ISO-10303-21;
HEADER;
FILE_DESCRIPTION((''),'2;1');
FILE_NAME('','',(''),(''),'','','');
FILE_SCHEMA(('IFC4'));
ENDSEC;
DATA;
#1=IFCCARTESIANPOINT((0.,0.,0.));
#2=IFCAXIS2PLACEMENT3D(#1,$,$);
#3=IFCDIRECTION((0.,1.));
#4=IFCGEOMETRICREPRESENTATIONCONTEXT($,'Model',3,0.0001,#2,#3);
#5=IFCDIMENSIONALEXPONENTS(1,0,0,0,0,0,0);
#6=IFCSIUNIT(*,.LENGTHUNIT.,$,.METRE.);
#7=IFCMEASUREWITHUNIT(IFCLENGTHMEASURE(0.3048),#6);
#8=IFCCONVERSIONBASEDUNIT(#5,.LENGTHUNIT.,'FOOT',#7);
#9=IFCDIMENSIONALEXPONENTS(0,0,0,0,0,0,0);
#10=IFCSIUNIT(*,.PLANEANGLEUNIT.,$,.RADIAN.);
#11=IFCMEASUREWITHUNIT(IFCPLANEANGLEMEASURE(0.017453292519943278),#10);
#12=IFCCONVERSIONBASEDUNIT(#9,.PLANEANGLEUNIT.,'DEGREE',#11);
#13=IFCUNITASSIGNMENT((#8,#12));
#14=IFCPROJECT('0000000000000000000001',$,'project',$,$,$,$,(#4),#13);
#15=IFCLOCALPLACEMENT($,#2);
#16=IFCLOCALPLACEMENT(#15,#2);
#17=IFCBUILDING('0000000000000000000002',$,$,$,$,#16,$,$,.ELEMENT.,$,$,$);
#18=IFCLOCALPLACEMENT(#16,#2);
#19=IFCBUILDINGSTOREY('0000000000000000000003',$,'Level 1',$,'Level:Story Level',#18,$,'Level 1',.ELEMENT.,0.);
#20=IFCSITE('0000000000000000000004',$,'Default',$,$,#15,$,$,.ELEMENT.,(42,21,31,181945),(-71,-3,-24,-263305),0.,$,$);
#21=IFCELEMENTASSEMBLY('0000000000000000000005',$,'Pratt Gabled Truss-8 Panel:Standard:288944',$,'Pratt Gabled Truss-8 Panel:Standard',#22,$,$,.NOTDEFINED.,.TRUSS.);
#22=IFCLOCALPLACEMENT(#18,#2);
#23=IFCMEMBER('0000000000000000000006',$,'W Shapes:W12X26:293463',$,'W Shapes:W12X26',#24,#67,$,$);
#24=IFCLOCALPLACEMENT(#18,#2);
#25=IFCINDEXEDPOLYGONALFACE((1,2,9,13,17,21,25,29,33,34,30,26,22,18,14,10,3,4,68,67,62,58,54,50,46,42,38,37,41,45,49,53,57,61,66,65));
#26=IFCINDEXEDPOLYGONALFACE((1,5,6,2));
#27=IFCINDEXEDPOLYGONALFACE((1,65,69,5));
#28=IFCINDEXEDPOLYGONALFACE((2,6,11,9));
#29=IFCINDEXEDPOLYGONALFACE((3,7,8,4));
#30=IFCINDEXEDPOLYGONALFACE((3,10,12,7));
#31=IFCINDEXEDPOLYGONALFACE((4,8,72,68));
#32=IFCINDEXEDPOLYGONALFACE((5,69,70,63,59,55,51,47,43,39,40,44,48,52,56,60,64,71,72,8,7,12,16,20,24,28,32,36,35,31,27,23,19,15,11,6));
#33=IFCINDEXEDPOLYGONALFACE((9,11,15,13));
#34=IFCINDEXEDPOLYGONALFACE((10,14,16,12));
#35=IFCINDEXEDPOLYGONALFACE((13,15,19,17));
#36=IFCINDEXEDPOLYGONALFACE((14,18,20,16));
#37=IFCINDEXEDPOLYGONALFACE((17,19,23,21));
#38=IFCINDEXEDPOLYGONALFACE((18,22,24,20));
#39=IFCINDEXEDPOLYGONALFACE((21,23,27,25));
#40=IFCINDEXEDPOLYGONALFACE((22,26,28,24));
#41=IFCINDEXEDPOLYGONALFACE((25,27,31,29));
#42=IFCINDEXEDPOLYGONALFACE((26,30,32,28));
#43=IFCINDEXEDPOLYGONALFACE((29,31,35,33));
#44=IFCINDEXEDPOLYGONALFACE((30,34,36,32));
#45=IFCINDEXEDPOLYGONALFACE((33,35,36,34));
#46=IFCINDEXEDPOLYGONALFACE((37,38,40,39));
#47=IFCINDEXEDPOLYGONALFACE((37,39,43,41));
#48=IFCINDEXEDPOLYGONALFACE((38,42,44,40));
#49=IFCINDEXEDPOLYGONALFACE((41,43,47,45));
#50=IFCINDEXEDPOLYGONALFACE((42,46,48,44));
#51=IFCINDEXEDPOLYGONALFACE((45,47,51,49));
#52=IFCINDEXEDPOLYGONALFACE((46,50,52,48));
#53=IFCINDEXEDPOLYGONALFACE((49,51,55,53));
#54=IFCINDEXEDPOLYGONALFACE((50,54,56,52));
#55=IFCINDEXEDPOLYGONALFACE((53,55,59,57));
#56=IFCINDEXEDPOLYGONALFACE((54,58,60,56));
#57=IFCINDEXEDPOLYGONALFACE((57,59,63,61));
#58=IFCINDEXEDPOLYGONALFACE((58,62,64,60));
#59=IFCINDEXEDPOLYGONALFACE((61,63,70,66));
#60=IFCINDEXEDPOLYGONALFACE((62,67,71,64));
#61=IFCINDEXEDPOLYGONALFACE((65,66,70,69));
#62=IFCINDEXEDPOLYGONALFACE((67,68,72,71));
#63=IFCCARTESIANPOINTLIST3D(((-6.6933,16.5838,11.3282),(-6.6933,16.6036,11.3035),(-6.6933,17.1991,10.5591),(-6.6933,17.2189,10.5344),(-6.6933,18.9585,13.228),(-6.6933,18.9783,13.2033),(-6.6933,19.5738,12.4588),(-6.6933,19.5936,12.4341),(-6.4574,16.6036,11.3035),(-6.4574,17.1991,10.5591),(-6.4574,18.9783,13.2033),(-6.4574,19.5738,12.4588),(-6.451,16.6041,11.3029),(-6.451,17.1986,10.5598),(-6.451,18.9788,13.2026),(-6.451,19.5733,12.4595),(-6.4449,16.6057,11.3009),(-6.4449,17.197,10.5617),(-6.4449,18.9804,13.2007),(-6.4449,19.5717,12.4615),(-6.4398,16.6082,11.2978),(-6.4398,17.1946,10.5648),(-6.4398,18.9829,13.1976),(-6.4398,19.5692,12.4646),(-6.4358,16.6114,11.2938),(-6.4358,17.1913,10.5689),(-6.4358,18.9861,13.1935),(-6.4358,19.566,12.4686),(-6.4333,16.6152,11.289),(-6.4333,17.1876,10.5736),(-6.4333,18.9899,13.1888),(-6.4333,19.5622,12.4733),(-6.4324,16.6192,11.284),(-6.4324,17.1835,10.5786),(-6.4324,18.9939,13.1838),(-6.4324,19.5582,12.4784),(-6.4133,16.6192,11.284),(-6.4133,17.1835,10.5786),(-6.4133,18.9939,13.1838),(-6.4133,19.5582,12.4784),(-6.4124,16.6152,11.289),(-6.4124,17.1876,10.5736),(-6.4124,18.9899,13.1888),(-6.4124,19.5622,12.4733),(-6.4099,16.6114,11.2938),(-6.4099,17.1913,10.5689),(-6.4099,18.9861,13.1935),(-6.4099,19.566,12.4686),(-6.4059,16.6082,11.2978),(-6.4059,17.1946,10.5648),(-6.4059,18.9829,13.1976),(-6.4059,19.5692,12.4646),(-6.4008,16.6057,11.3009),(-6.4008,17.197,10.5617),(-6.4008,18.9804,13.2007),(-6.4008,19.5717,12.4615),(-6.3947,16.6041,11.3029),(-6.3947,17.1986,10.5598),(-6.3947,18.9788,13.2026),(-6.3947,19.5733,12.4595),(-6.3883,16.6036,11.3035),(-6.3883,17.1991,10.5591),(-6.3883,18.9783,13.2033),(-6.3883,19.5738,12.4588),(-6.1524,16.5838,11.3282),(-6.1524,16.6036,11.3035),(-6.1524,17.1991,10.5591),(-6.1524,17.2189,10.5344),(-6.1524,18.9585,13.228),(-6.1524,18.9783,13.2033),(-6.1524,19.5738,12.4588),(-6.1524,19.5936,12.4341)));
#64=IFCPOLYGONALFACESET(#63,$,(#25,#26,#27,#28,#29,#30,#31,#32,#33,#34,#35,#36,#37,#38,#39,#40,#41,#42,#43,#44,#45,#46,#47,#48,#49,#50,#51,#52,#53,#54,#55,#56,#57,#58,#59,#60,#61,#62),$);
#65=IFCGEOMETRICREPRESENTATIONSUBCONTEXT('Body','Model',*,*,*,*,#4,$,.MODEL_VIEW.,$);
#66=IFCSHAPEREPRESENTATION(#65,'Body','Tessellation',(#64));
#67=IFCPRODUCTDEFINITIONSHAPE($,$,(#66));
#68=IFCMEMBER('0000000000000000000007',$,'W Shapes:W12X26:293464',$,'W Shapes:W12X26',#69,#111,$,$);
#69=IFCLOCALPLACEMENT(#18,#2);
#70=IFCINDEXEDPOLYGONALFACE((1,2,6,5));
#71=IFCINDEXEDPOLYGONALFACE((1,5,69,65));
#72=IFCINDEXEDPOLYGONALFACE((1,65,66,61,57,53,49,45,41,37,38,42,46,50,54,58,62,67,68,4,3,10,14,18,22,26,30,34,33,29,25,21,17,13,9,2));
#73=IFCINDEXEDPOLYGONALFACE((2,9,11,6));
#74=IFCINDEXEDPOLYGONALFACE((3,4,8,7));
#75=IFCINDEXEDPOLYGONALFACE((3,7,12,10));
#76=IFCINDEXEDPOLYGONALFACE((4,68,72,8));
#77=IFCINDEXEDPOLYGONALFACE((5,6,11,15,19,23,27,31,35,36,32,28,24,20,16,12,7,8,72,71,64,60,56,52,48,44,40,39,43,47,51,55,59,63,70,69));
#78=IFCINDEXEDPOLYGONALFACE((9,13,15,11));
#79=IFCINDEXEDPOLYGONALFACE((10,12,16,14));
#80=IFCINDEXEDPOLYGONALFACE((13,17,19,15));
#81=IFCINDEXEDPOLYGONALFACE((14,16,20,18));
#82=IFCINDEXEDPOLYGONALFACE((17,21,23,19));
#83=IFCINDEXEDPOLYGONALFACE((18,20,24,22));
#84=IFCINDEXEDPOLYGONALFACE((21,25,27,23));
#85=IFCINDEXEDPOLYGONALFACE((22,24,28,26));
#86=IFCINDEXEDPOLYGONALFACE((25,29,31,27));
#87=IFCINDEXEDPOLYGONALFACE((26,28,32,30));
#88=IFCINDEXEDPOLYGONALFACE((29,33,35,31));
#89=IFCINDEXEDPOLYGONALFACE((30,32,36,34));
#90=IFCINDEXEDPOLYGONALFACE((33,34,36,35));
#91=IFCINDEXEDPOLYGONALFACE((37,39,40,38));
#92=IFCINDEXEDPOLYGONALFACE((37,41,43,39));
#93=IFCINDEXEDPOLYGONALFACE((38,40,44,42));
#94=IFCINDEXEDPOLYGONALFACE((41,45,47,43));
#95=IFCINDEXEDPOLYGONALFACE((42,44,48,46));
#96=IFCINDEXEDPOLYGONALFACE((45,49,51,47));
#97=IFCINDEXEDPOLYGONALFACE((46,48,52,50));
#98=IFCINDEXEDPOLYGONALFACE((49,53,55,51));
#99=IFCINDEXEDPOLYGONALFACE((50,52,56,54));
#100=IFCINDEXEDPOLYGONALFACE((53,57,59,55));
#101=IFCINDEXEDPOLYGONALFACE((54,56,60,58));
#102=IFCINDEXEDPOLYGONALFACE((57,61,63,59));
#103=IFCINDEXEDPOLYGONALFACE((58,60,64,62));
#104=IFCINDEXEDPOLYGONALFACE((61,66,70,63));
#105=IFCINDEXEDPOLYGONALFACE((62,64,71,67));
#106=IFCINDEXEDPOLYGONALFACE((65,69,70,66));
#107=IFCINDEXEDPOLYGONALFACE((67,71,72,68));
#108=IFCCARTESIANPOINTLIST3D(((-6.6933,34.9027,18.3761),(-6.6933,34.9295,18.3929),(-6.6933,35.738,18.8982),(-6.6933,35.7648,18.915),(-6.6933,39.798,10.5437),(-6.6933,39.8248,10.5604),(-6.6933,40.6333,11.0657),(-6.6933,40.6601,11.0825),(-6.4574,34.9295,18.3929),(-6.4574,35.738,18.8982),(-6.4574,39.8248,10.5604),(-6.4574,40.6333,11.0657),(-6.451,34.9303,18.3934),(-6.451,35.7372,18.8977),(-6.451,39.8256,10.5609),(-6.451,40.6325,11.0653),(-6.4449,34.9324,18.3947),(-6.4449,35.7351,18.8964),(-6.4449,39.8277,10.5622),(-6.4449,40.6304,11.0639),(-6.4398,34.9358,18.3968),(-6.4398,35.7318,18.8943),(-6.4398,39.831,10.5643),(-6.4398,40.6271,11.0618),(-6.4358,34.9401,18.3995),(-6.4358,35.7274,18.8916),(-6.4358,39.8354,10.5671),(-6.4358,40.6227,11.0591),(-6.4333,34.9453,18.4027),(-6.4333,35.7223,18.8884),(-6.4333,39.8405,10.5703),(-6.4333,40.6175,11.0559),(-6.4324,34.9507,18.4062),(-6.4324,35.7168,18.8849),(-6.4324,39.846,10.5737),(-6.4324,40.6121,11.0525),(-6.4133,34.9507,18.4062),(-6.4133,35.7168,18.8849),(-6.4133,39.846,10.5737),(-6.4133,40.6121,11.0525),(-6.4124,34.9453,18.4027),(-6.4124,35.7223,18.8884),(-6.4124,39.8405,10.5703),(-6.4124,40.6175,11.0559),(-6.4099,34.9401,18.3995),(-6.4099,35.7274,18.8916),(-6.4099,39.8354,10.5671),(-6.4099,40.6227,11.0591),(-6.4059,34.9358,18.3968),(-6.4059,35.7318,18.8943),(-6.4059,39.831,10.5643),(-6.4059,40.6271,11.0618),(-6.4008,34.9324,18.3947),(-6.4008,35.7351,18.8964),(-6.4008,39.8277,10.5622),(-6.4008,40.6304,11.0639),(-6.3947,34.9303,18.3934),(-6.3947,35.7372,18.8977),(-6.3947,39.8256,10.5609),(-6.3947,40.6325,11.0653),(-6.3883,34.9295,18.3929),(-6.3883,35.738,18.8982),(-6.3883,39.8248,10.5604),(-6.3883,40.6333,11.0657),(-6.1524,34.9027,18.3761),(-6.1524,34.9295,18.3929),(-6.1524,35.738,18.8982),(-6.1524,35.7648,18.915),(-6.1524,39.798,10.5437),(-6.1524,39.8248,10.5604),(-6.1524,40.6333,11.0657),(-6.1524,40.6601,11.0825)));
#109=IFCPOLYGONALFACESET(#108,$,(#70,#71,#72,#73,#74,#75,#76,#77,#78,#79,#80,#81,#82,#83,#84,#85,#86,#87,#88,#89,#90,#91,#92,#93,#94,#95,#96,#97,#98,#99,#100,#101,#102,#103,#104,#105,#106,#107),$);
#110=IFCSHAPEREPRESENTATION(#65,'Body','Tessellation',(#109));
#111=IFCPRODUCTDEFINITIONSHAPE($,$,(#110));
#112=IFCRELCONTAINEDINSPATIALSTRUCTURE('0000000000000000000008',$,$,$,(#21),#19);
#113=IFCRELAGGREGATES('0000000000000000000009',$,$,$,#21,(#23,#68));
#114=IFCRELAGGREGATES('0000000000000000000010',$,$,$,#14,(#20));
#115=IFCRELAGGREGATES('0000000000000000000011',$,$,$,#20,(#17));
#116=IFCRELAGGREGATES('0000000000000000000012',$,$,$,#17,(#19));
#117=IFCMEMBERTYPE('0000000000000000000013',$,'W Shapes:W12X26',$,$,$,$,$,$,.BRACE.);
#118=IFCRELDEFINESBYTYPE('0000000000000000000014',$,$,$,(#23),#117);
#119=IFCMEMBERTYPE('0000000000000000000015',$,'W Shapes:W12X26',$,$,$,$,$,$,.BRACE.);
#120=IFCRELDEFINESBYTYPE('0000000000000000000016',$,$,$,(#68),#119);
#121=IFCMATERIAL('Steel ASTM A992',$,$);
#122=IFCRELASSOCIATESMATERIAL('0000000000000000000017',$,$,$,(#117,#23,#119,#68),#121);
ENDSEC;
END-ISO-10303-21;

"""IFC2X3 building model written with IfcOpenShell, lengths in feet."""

from ifc_helpers import new_model, entity, si_unit, converted_unit, direction, frame, frame_2d, origin, place, context, subcontext, project, spatial, polyline, circle_curve, parameter, trimmed, segment, composite_curve, outline, extrude, source, transform, mapped, material, type_object, type_shapes, element, aggregate, save


model = new_model("IFC2X3")

# Units and contexts
model_context = context("Model", 3, precision=0.0001, world=origin(), true_north=direction((0.0, 1.0)))
body_context = subcontext(model_context, "Body", "Model", "MODEL_VIEW")
ifc_project = project(units=[converted_unit("LENGTHUNIT", "FOOT", entity("IfcLengthMeasure", 0.3048), si_unit("LENGTHUNIT", "METRE"), dimensions=[1, 0, 0, 0, 0, 0, 0]), converted_unit("PLANEANGLEUNIT", "DEGREE", entity("IfcPlaneAngleMeasure", 0.017453292519943278), si_unit("PLANEANGLEUNIT", "RADIAN"), dimensions=[0, 0, 0, 0, 0, 0, 0])], contexts=[model_context])

# Site, building, storey
site_placement = place(None, origin())
site = spatial("IfcSite", under=ifc_project, at=site_placement, Name="Default", CompositionType="ELEMENT", RefLatitude=(42, 21, 31, 181945), RefLongitude=(-71, -3, -24, -263305), RefElevation=0.0)
building_placement = place(site_placement, origin())
building = spatial("IfcBuilding", under=site, at=building_placement, CompositionType="ELEMENT")
storey_placement = place(building_placement, origin())
storey = spatial("IfcBuildingStorey", under=building, at=storey_placement, Name="Level 1", ObjectType="Level:Story Level", LongName="Level 1", CompositionType="ELEMENT", Elevation=0.0)

# Element assembly, members
assembly_placement = place(storey_placement, origin())
assembly = element("IfcElementAssembly", 1, at=assembly_placement, inside=storey, Name="Pratt Gabled Truss-8 Panel:Standard:288944", ObjectType="Pratt Gabled Truss-8 Panel:Standard", AssemblyPlace="NOTDEFINED", PredefinedType="TRUSS")
ifc_material = material(Name="Steel ASTM A992")
member_type_1 = type_object("IfcMemberType", Name="W Shapes:W12X26", PredefinedType="BRACE", material=ifc_material)
shared_shape_1 = source(origin(), body_context, "Body", "SweptSolid", [
    extrude(outline(composite_curve([segment(polyline([(-0.2704, -0.4767), (-0.2704, -0.5083)]), True, "CONTINUOUS"), segment(polyline([(-0.2704, -0.5083), (0.2704, -0.5083)]), True, "CONTINUOUS"), segment(polyline([(0.2704, -0.5083), (0.2704, -0.4767)]), True, "CONTINUOUS"), segment(polyline([(0.2704, -0.4767), (0.0346, -0.4767)]), True, "CONTINUOUS"), segment(trimmed(circle_curve(frame_2d((0.0346, -0.4517), x_axis=(1.0, 0.0)), 0.025), [parameter(180.0)], [parameter(270.0)], True, "PARAMETER"), False, "CONTINUOUS"), segment(polyline([(0.0096, -0.4517), (0.0096, 0.4517)]), True, "CONTINUOUS"), segment(trimmed(circle_curve(frame_2d((0.0346, 0.4517), x_axis=(1.0, 0.0)), 0.025), [parameter(90.0)], [parameter(180.0)], True, "PARAMETER"), False, "CONTINUOUS"), segment(polyline([(0.0346, 0.4767), (0.2704, 0.4767)]), True, "CONTINUOUS"), segment(polyline([(0.2704, 0.4767), (0.2704, 0.5083)]), True, "CONTINUOUS"), segment(polyline([(0.2704, 0.5083), (-0.2704, 0.5083)]), True, "CONTINUOUS"), segment(polyline([(-0.2704, 0.5083), (-0.2704, 0.4767)]), True, "CONTINUOUS"), segment(polyline([(-0.2704, 0.4767), (-0.0346, 0.4767)]), True, "CONTINUOUS"), segment(trimmed(circle_curve(frame_2d((-0.0346, 0.4517), x_axis=(1.0, 0.0)), 0.025), [parameter(360.0)], [parameter(90.0)], True, "PARAMETER"), False, "CONTINUOUS"), segment(polyline([(-0.0096, 0.4517), (-0.0096, -0.4517)]), True, "CONTINUOUS"), segment(trimmed(circle_curve(frame_2d((-0.0346, -0.4517), x_axis=(1.0, 0.0)), 0.025), [parameter(270.0)], [parameter(360.0)], True, "PARAMETER"), False, "CONTINUOUS"), segment(polyline([(-0.0346, -0.4767), (-0.2704, -0.4767)]), True, "CONTINUOUS")], self_intersect=False)), frame((-2.5111, 0.0, 0.0), z_axis=(-1.0, 0.0, 0.0), x_axis=(0.0, -1.0, 0.0)), (0.0, 0.0, -1.0), 3.0411),
])
type_shapes(member_type_1, [shared_shape_1])
member_1_placement = place(assembly_placement, frame((-6.4228, 18.8622, 12.5), z_axis=(0.0, 0.624695, -0.780869), x_axis=(0.0, 0.780869, 0.624695)))
member_1 = element("IfcMember", 2, at=member_1_placement, type_object=member_type_1, material=ifc_material, Name="W Shapes:W12X26:293463", ObjectType="W Shapes:W12X26", context=body_context, shape_type="MappedRepresentation", body=[
    mapped(shared_shape_1, transform((0.0, 0.0, 0.0), scale=1.0)),
])
member_type_2 = type_object("IfcMemberType", Name="W Shapes:W12X26", PredefinedType="BRACE", material=ifc_material)
shared_shape_2 = source(origin(), body_context, "Body", "SweptSolid", [
    extrude(outline(composite_curve([segment(polyline([(-0.2704, -0.4767), (-0.2704, -0.5083)]), True, "CONTINUOUS"), segment(polyline([(-0.2704, -0.5083), (0.2704, -0.5083)]), True, "CONTINUOUS"), segment(polyline([(0.2704, -0.5083), (0.2704, -0.4767)]), True, "CONTINUOUS"), segment(polyline([(0.2704, -0.4767), (0.0346, -0.4767)]), True, "CONTINUOUS"), segment(trimmed(circle_curve(frame_2d((0.0346, -0.4517), x_axis=(1.0, 0.0)), 0.025), [parameter(180.0)], [parameter(270.0)], True, "PARAMETER"), False, "CONTINUOUS"), segment(polyline([(0.0096, -0.4517), (0.0096, 0.4517)]), True, "CONTINUOUS"), segment(trimmed(circle_curve(frame_2d((0.0346, 0.4517), x_axis=(1.0, 0.0)), 0.025), [parameter(90.0)], [parameter(180.0)], True, "PARAMETER"), False, "CONTINUOUS"), segment(polyline([(0.0346, 0.4767), (0.2704, 0.4767)]), True, "CONTINUOUS"), segment(polyline([(0.2704, 0.4767), (0.2704, 0.5083)]), True, "CONTINUOUS"), segment(polyline([(0.2704, 0.5083), (-0.2704, 0.5083)]), True, "CONTINUOUS"), segment(polyline([(-0.2704, 0.5083), (-0.2704, 0.4767)]), True, "CONTINUOUS"), segment(polyline([(-0.2704, 0.4767), (-0.0346, 0.4767)]), True, "CONTINUOUS"), segment(trimmed(circle_curve(frame_2d((-0.0346, 0.4517), x_axis=(1.0, 0.0)), 0.025), [parameter(360.0)], [parameter(90.0)], True, "PARAMETER"), False, "CONTINUOUS"), segment(polyline([(-0.0096, 0.4517), (-0.0096, -0.4517)]), True, "CONTINUOUS"), segment(trimmed(circle_curve(frame_2d((-0.0346, -0.4517), x_axis=(1.0, 0.0)), 0.025), [parameter(270.0)], [parameter(360.0)], True, "PARAMETER"), False, "CONTINUOUS"), segment(polyline([(-0.0346, -0.4767), (-0.2704, -0.4767)]), True, "CONTINUOUS")], self_intersect=False)), frame((-4.299, 0.0, 0.0), z_axis=(-1.0, 0.0, 0.0), x_axis=(0.0, -1.0, 0.0)), (0.0, 0.0, -1.0), 9.2364),
])
type_shapes(member_type_2, [shared_shape_2])
member_2_placement = place(assembly_placement, frame((-6.4228, 37.6122, 15.0), z_axis=(0.0, -0.847998, -0.529999), x_axis=(0.0, 0.529999, -0.847998)))
member_2 = element("IfcMember", 3, at=member_2_placement, type_object=member_type_2, material=ifc_material, Name="W Shapes:W12X26:293464", ObjectType="W Shapes:W12X26", context=body_context, shape_type="MappedRepresentation", body=[
    mapped(shared_shape_2, transform((0.0, 0.0, 0.0), scale=1.0)),
])
aggregate(assembly, [member_1, member_2])

save(model, "model.ifc")
